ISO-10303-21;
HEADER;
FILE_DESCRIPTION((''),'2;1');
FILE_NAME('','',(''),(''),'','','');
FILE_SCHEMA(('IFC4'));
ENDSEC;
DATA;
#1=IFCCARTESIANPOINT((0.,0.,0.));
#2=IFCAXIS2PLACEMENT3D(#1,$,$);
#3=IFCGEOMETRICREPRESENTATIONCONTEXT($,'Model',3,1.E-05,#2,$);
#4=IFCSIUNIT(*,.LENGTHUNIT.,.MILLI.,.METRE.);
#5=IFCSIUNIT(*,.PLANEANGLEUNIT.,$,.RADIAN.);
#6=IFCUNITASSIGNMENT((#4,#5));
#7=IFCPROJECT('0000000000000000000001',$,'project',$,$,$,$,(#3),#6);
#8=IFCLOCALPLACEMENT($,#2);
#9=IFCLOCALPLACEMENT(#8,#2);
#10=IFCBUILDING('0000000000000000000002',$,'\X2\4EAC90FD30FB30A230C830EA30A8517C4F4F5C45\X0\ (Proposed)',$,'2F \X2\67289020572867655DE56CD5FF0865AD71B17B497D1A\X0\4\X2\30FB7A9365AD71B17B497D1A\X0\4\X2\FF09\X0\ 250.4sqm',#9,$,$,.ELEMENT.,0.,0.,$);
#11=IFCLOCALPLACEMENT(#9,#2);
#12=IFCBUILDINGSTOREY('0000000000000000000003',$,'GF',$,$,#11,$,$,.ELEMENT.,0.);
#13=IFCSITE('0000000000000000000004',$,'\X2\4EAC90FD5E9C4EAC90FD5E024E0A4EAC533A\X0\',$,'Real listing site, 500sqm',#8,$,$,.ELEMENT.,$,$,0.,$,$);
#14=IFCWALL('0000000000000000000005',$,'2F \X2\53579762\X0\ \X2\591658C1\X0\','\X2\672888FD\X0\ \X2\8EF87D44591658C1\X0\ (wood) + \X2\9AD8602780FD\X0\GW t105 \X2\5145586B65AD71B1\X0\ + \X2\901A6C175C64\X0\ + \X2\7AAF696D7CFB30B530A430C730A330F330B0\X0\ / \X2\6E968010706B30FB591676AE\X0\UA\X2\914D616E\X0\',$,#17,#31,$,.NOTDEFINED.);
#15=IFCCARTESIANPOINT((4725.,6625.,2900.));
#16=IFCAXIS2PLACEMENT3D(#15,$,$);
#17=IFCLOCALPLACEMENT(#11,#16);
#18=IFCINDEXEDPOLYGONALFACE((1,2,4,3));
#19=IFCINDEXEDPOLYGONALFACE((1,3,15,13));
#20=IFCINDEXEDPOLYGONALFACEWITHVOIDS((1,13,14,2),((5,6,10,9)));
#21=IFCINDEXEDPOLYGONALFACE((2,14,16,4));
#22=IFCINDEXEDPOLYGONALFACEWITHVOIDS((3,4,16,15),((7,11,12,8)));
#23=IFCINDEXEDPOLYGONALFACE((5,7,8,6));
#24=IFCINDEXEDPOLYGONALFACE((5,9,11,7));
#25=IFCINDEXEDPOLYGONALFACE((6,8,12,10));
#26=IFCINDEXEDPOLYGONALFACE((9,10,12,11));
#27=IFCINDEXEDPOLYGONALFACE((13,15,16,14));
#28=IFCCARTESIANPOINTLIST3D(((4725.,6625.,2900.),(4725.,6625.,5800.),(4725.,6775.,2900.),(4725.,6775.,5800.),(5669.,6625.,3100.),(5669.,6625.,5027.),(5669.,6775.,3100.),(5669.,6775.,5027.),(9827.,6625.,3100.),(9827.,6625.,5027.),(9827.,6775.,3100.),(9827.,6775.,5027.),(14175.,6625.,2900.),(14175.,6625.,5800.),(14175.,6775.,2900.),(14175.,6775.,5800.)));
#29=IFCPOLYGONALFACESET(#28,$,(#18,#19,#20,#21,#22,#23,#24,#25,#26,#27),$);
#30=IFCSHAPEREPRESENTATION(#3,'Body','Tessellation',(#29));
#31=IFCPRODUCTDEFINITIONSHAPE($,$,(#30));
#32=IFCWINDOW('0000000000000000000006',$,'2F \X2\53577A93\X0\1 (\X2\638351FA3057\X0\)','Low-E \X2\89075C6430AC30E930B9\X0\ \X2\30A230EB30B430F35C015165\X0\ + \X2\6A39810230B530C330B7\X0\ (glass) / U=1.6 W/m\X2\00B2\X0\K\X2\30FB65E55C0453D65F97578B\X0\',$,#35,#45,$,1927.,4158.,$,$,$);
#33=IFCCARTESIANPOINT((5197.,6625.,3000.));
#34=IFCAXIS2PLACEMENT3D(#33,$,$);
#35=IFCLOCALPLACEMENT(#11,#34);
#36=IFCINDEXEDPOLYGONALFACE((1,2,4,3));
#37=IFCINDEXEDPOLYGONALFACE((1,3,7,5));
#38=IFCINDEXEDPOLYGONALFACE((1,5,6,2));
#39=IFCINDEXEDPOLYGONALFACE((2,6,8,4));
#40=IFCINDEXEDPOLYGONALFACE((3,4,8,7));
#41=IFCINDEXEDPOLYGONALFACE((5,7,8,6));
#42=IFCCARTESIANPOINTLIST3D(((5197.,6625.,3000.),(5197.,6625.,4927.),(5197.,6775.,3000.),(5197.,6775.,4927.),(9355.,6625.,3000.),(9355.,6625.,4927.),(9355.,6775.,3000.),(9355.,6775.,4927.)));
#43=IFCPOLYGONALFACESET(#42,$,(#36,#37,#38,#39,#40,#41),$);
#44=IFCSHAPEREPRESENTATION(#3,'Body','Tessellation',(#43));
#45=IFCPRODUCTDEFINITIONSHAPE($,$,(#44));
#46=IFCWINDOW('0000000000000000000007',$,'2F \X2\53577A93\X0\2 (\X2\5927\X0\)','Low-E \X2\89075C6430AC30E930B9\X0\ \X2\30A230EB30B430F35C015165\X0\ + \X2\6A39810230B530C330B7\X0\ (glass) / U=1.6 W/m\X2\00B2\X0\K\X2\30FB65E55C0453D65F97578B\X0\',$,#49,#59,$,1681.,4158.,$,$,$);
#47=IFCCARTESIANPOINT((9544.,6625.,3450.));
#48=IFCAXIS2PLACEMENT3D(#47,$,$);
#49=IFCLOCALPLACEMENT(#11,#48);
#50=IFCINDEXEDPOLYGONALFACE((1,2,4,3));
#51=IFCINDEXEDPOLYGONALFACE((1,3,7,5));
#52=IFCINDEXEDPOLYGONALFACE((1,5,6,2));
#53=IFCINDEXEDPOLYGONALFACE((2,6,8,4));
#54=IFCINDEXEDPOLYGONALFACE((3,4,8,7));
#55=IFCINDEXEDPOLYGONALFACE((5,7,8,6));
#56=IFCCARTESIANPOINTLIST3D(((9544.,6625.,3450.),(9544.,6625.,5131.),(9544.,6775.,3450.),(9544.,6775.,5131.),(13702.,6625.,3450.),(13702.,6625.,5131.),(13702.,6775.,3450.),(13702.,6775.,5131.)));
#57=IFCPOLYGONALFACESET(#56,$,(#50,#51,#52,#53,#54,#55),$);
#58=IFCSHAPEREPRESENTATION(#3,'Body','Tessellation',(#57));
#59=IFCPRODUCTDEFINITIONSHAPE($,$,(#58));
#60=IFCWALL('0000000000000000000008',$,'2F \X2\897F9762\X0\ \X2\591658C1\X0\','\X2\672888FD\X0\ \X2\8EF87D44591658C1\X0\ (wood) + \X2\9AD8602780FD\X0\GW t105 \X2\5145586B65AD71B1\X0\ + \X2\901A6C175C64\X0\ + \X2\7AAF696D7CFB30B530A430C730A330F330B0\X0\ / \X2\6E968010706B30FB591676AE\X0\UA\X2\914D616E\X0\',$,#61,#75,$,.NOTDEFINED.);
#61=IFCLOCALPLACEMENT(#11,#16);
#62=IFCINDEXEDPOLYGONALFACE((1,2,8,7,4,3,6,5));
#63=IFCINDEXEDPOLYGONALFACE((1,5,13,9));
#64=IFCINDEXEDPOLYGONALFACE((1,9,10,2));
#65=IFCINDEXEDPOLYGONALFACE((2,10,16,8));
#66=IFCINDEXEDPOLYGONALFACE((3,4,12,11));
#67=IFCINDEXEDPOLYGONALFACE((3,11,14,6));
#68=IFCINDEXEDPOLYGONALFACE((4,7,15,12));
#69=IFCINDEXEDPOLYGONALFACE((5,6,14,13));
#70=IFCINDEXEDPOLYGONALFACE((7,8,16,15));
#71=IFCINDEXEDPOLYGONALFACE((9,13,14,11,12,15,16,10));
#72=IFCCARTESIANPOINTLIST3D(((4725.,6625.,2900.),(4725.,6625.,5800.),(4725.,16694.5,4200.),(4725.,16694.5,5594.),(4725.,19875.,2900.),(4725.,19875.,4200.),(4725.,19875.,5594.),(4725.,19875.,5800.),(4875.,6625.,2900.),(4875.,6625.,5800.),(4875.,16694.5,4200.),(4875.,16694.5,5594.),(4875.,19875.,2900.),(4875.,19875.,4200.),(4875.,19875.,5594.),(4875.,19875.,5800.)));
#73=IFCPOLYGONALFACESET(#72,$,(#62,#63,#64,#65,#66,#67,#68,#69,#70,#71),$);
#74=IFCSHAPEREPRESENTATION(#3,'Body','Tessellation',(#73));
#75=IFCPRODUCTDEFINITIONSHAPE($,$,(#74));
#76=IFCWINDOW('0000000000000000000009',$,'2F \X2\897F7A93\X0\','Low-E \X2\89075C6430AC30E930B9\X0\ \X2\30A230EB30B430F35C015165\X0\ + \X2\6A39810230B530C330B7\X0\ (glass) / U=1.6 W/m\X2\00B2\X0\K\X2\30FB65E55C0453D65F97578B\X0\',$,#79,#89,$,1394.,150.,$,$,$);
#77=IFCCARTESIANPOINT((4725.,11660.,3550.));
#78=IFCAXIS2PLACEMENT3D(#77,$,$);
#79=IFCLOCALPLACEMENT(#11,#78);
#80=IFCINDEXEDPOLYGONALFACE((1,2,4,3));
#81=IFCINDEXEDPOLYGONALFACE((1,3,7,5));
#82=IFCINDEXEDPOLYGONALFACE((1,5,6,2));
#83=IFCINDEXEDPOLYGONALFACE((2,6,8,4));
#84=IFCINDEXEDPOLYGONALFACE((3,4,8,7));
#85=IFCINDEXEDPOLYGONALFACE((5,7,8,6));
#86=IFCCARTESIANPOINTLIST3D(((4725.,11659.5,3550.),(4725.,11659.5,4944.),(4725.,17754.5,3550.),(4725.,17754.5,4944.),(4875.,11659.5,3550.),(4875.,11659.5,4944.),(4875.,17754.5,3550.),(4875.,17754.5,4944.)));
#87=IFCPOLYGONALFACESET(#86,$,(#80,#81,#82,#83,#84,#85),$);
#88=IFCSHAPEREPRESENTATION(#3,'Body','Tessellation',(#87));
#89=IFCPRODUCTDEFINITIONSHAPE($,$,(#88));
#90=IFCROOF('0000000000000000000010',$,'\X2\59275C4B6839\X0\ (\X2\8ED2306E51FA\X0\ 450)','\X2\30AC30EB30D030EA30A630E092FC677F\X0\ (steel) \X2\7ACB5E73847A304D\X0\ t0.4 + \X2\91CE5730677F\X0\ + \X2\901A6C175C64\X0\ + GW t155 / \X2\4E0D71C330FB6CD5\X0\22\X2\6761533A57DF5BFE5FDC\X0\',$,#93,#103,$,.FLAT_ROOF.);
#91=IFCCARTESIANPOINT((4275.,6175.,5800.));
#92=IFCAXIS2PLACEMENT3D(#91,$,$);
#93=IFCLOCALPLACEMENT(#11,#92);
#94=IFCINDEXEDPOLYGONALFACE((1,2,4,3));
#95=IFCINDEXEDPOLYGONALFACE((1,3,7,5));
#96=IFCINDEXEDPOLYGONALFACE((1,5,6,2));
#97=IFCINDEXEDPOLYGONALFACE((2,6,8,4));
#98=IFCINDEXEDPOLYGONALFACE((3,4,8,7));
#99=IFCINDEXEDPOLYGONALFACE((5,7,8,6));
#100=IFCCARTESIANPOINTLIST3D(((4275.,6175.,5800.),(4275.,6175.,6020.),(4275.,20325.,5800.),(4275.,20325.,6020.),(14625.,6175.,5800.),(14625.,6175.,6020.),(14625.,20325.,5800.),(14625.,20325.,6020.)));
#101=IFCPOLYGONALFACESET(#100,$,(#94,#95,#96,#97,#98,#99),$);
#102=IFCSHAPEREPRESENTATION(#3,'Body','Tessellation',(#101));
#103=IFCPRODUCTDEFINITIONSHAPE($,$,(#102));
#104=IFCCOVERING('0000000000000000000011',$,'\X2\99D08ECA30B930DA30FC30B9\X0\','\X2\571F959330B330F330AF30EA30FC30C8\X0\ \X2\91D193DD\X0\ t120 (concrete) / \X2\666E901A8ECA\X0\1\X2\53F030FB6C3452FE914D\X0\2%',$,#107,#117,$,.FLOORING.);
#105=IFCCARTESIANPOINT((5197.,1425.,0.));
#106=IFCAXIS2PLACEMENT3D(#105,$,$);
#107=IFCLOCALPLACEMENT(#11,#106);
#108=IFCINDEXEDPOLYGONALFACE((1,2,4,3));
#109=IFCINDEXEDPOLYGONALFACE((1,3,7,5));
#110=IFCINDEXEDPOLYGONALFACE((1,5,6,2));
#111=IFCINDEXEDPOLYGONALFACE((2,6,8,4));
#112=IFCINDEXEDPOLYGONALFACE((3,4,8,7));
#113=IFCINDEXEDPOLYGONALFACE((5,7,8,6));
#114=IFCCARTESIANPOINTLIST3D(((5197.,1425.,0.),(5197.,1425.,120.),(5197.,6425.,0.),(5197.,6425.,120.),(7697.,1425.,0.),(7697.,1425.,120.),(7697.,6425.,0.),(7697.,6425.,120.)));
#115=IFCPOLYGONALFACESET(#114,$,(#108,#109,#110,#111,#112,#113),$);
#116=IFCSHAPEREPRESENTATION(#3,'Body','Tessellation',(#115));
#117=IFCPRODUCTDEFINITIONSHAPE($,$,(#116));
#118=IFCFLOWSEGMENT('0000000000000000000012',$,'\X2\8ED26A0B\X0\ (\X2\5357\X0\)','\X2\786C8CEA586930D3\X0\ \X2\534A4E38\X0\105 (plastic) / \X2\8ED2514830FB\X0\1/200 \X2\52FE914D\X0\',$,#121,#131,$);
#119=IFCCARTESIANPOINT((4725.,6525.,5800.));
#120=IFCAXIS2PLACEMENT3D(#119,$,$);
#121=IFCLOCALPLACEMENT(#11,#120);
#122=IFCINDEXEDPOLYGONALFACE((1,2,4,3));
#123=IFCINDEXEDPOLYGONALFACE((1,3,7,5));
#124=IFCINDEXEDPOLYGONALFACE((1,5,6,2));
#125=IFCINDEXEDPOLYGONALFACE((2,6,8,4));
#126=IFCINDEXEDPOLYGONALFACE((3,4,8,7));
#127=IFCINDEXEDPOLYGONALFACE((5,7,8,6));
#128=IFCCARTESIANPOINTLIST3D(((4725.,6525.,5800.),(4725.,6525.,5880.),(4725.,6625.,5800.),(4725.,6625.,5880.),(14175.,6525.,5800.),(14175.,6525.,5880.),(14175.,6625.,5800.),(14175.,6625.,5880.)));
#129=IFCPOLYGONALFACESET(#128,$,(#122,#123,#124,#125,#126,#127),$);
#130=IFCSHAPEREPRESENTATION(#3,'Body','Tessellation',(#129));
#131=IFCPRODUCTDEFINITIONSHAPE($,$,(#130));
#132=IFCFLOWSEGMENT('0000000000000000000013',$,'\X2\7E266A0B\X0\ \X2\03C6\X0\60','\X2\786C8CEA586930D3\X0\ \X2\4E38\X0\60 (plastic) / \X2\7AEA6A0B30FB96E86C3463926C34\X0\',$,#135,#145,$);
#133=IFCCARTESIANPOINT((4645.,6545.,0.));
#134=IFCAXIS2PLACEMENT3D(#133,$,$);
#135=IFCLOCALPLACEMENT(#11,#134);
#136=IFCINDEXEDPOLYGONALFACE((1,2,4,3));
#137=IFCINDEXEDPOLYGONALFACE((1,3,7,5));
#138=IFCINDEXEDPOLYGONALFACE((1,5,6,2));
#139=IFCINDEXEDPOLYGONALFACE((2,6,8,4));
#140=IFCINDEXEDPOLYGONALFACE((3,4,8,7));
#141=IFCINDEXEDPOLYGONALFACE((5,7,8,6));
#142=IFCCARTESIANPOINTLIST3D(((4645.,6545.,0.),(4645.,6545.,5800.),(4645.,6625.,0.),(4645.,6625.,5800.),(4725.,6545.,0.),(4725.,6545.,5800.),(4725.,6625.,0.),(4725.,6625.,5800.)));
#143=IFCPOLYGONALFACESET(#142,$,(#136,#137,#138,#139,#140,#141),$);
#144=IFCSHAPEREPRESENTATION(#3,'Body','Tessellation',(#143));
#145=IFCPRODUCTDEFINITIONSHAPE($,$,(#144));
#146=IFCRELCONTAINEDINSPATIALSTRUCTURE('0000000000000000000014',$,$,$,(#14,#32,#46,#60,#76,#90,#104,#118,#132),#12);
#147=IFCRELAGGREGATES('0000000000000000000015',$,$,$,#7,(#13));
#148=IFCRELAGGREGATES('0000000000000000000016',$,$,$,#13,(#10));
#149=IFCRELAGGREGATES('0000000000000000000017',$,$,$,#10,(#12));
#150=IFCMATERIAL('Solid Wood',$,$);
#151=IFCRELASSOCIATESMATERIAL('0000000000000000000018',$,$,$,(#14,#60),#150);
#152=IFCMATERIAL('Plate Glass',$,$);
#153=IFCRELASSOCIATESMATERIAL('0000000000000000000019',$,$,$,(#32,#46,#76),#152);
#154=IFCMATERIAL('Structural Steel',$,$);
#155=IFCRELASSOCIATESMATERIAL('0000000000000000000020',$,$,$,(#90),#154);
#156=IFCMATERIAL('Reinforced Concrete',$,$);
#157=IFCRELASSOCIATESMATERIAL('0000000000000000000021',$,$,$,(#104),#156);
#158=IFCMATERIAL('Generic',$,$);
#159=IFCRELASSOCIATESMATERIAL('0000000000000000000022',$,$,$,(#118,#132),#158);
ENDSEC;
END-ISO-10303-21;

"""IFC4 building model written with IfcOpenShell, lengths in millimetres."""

from ifc_helpers import new_model, si_unit, frame, frame_2d, origin, place, context, project, spatial, rectangle, extrude, material, element, fill, save


model = new_model("IFC4")

# Units and contexts
model_context = context("Model", 3, precision=1e-05, world=origin())
ifc_project = project(units=[si_unit("LENGTHUNIT", "METRE", prefix="MILLI"), si_unit("PLANEANGLEUNIT", "RADIAN")], contexts=[model_context])

# Site, building, storey
site_placement = place(None, origin())
site = spatial("IfcSite", under=ifc_project, at=site_placement, Name="京都府京都市上京区", ObjectType="Real listing site, 500sqm", CompositionType="ELEMENT", RefElevation=0.0)
building_placement = place(site_placement, origin())
building = spatial("IfcBuilding", under=site, at=building_placement, Name="京都・アトリエ兼住居 (Proposed)", ObjectType="2F 木造在来工法（断熱等級4・窓断熱等級4） 250.4sqm", CompositionType="ELEMENT", ElevationOfRefHeight=0.0, ElevationOfTerrain=0.0)
storey_placement = place(building_placement, origin())
storey = spatial("IfcBuildingStorey", under=building, at=storey_placement, Name="GF", CompositionType="ELEMENT", Elevation=0.0)

# Shared definitions
ifc_material_1 = material(Name="Solid Wood")

# Shared definitions
ifc_material_2 = material(Name="Reinforced Concrete")

# Shared definitions
ifc_material_3 = material(Name="Plate Glass")

# Wall, openings, windows
wall_1_placement = place(storey_placement, frame((4725.0, 6625.0, 2900.0)))
wall_1 = element("IfcWall", 1, at=wall_1_placement, inside=storey, material=ifc_material_1, Name="2F 南面 外壁", Description="木製 軸組外壁 (wood) + 高性能GW t105 充填断熱 + 通気層 + 窯業系サイディング / 準耐火・外皮UA配慮", PredefinedType="NOTDEFINED", context=model_context, shape_type="SweptSolid", body=[
    extrude(rectangle(XDim=9450.0, YDim=150.0, at=frame_2d((4725.0, 75.0))), frame((4725.0, 6625.0, 2900.0)), (0.0, 0.0, 1.0), 2900.0),
])
opening_1_placement = place(storey_placement, frame((5197.0, 6625.0, 3000.0)))
opening_1 = element("IfcOpeningElement", 2, at=opening_1_placement, cuts=wall_1, PredefinedType="NOTDEFINED", context=model_context, shape_type="SweptSolid", body=[
    extrude(rectangle(XDim=4158.0, YDim=150.0, at=frame_2d((2079.0, 75.0))), frame((5197.0, 6625.0, 3000.0)), (0.0, 0.0, 1.0), 1927.0),
])
opening_2_placement = place(storey_placement, frame((9544.0, 6625.0, 3450.0)))
opening_2 = element("IfcOpeningElement", 3, at=opening_2_placement, cuts=wall_1, PredefinedType="NOTDEFINED", context=model_context, shape_type="SweptSolid", body=[
    extrude(rectangle(XDim=4158.0, YDim=150.0, at=frame_2d((2079.0, 75.0))), frame((9544.0, 6625.0, 3450.0)), (0.0, 0.0, 1.0), 1681.0),
])
window_1_placement = place(storey_placement, frame((5197.0, 6625.0, 3000.0)))
window_1 = element("IfcWindow", 4, at=window_1_placement, inside=storey, material=ifc_material_3, Name="2F 南窓1 (掃出し)", Description="Low-E 複層ガラス アルゴン封入 + 樹脂サッシ (glass) / U=1.6 W/m²K・日射取得型", OverallHeight=1927.0, OverallWidth=4158.0, context=model_context, shape_type="SweptSolid", body=[
    extrude(rectangle(XDim=4158.0, YDim=150.0, at=frame_2d((2079.0, 75.0))), frame((5197.0, 6625.0, 3000.0)), (0.0, 0.0, 1.0), 1927.0),
])
fill(opening_1, window_1)
window_2_placement = place(storey_placement, frame((9544.0, 6625.0, 3450.0)))
window_2 = element("IfcWindow", 5, at=window_2_placement, inside=storey, material=ifc_material_3, Name="2F 南窓2 (大)", Description="Low-E 複層ガラス アルゴン封入 + 樹脂サッシ (glass) / U=1.6 W/m²K・日射取得型", OverallHeight=1681.0, OverallWidth=4158.0, context=model_context, shape_type="SweptSolid", body=[
    extrude(rectangle(XDim=4158.0, YDim=150.0, at=frame_2d((2079.0, 75.0))), frame((9544.0, 6625.0, 3450.0)), (0.0, 0.0, 1.0), 1681.0),
])
fill(opening_2, window_2)

# Wall, opening, window
wall_2_placement = place(storey_placement, frame((4725.0, 6625.0, 2900.0)))
wall_2 = element("IfcWall", 6, at=wall_2_placement, inside=storey, material=ifc_material_1, Name="2F 西面 外壁", Description="木製 軸組外壁 (wood) + 高性能GW t105 充填断熱 + 通気層 + 窯業系サイディング / 準耐火・外皮UA配慮", PredefinedType="NOTDEFINED", context=model_context, shape_type="SweptSolid", body=[
    extrude(rectangle(XDim=150.0, YDim=13250.0, at=frame_2d((75.0, 6625.0))), frame((4725.0, 6625.0, 2900.0)), (0.0, 0.0, 1.0), 2900.0),
])
opening_3_placement = place(storey_placement, frame((4725.0, 11660.0, 3550.0)))
opening_3 = element("IfcOpeningElement", 7, at=opening_3_placement, cuts=wall_2, PredefinedType="NOTDEFINED", context=model_context, shape_type="SweptSolid", body=[
    extrude(rectangle(XDim=150.0, YDim=6095.0, at=frame_2d((75.0, 3047.0))), frame((4725.0, 11660.0, 3550.0)), (0.0, 0.0, 1.0), 1394.0),
])
window_3_placement = place(storey_placement, frame((4725.0, 11660.0, 3550.0)))
window_3 = element("IfcWindow", 8, at=window_3_placement, inside=storey, material=ifc_material_3, Name="2F 西窓", Description="Low-E 複層ガラス アルゴン封入 + 樹脂サッシ (glass) / U=1.6 W/m²K・日射取得型", OverallHeight=1394.0, OverallWidth=150.0, context=model_context, shape_type="SweptSolid", body=[
    extrude(rectangle(XDim=150.0, YDim=6095.0, at=frame_2d((75.0, 3047.0))), frame((4725.0, 11660.0, 3550.0)), (0.0, 0.0, 1.0), 1394.0),
])
fill(opening_3, window_3)

# Roof
ifc_material_4 = material(Name="Structural Steel")
roof_placement = place(storey_placement, frame((4275.0, 6175.0, 5800.0)))
element("IfcRoof", 9, at=roof_placement, inside=storey, material=ifc_material_4, Name="大屋根 (軒の出 450)", Description="ガルバリウム鋼板 (steel) 立平葺き t0.4 + 野地板 + 通気層 + GW t155 / 不燃・法22条区域対応", PredefinedType="FLAT_ROOF", context=model_context, shape_type="SweptSolid", body=[
    extrude(rectangle(XDim=10350.0, YDim=14150.0, at=frame_2d((5175.0, 7075.0))), frame((4275.0, 6175.0, 5800.0)), (0.0, 0.0, 1.0), 220.0),
])

# Covering
covering_placement = place(storey_placement, frame((5197.0, 1425.0, 0.0)))
element("IfcCovering", 10, at=covering_placement, inside=storey, material=ifc_material_2, Name="駐車スペース", Description="土間コンクリート 金鏝 t120 (concrete) / 普通車1台・水勾配2%", PredefinedType="FLOORING", context=model_context, shape_type="SweptSolid", body=[
    extrude(rectangle(XDim=2500.0, YDim=5000.0, at=frame_2d((1250.0, 2500.0))), frame((5197.0, 1425.0, 0.0)), (0.0, 0.0, 1.0), 120.0),
])

# Flow segments
ifc_material_5 = material(Name="Generic")
flow_segment_1_placement = place(storey_placement, frame((4725.0, 6525.0, 5800.0)))
element("IfcFlowSegment", 11, at=flow_segment_1_placement, inside=storey, material=ifc_material_5, Name="軒樋 (南)", Description="硬質塩ビ 半丸105 (plastic) / 軒先・1/200 勾配", context=model_context, shape_type="SweptSolid", body=[
    extrude(rectangle(XDim=9450.0, YDim=100.0, at=frame_2d((4725.0, 50.0))), frame((4725.0, 6525.0, 5800.0)), (0.0, 0.0, 1.0), 80.0),
])
flow_segment_2_placement = place(storey_placement, frame((4645.0, 6545.0, 0.0)))
element("IfcFlowSegment", 12, at=flow_segment_2_placement, inside=storey, material=ifc_material_5, Name="縦樋 φ60", Description="硬質塩ビ 丸60 (plastic) / 竪樋・雨水排水", context=model_context, shape_type="SweptSolid", body=[
    extrude(rectangle(XDim=80.0, YDim=80.0, at=frame_2d((40.0, 40.0))), frame((4645.0, 6545.0, 0.0)), (0.0, 0.0, 1.0), 5800.0),
])

save(model, "model.ifc")
